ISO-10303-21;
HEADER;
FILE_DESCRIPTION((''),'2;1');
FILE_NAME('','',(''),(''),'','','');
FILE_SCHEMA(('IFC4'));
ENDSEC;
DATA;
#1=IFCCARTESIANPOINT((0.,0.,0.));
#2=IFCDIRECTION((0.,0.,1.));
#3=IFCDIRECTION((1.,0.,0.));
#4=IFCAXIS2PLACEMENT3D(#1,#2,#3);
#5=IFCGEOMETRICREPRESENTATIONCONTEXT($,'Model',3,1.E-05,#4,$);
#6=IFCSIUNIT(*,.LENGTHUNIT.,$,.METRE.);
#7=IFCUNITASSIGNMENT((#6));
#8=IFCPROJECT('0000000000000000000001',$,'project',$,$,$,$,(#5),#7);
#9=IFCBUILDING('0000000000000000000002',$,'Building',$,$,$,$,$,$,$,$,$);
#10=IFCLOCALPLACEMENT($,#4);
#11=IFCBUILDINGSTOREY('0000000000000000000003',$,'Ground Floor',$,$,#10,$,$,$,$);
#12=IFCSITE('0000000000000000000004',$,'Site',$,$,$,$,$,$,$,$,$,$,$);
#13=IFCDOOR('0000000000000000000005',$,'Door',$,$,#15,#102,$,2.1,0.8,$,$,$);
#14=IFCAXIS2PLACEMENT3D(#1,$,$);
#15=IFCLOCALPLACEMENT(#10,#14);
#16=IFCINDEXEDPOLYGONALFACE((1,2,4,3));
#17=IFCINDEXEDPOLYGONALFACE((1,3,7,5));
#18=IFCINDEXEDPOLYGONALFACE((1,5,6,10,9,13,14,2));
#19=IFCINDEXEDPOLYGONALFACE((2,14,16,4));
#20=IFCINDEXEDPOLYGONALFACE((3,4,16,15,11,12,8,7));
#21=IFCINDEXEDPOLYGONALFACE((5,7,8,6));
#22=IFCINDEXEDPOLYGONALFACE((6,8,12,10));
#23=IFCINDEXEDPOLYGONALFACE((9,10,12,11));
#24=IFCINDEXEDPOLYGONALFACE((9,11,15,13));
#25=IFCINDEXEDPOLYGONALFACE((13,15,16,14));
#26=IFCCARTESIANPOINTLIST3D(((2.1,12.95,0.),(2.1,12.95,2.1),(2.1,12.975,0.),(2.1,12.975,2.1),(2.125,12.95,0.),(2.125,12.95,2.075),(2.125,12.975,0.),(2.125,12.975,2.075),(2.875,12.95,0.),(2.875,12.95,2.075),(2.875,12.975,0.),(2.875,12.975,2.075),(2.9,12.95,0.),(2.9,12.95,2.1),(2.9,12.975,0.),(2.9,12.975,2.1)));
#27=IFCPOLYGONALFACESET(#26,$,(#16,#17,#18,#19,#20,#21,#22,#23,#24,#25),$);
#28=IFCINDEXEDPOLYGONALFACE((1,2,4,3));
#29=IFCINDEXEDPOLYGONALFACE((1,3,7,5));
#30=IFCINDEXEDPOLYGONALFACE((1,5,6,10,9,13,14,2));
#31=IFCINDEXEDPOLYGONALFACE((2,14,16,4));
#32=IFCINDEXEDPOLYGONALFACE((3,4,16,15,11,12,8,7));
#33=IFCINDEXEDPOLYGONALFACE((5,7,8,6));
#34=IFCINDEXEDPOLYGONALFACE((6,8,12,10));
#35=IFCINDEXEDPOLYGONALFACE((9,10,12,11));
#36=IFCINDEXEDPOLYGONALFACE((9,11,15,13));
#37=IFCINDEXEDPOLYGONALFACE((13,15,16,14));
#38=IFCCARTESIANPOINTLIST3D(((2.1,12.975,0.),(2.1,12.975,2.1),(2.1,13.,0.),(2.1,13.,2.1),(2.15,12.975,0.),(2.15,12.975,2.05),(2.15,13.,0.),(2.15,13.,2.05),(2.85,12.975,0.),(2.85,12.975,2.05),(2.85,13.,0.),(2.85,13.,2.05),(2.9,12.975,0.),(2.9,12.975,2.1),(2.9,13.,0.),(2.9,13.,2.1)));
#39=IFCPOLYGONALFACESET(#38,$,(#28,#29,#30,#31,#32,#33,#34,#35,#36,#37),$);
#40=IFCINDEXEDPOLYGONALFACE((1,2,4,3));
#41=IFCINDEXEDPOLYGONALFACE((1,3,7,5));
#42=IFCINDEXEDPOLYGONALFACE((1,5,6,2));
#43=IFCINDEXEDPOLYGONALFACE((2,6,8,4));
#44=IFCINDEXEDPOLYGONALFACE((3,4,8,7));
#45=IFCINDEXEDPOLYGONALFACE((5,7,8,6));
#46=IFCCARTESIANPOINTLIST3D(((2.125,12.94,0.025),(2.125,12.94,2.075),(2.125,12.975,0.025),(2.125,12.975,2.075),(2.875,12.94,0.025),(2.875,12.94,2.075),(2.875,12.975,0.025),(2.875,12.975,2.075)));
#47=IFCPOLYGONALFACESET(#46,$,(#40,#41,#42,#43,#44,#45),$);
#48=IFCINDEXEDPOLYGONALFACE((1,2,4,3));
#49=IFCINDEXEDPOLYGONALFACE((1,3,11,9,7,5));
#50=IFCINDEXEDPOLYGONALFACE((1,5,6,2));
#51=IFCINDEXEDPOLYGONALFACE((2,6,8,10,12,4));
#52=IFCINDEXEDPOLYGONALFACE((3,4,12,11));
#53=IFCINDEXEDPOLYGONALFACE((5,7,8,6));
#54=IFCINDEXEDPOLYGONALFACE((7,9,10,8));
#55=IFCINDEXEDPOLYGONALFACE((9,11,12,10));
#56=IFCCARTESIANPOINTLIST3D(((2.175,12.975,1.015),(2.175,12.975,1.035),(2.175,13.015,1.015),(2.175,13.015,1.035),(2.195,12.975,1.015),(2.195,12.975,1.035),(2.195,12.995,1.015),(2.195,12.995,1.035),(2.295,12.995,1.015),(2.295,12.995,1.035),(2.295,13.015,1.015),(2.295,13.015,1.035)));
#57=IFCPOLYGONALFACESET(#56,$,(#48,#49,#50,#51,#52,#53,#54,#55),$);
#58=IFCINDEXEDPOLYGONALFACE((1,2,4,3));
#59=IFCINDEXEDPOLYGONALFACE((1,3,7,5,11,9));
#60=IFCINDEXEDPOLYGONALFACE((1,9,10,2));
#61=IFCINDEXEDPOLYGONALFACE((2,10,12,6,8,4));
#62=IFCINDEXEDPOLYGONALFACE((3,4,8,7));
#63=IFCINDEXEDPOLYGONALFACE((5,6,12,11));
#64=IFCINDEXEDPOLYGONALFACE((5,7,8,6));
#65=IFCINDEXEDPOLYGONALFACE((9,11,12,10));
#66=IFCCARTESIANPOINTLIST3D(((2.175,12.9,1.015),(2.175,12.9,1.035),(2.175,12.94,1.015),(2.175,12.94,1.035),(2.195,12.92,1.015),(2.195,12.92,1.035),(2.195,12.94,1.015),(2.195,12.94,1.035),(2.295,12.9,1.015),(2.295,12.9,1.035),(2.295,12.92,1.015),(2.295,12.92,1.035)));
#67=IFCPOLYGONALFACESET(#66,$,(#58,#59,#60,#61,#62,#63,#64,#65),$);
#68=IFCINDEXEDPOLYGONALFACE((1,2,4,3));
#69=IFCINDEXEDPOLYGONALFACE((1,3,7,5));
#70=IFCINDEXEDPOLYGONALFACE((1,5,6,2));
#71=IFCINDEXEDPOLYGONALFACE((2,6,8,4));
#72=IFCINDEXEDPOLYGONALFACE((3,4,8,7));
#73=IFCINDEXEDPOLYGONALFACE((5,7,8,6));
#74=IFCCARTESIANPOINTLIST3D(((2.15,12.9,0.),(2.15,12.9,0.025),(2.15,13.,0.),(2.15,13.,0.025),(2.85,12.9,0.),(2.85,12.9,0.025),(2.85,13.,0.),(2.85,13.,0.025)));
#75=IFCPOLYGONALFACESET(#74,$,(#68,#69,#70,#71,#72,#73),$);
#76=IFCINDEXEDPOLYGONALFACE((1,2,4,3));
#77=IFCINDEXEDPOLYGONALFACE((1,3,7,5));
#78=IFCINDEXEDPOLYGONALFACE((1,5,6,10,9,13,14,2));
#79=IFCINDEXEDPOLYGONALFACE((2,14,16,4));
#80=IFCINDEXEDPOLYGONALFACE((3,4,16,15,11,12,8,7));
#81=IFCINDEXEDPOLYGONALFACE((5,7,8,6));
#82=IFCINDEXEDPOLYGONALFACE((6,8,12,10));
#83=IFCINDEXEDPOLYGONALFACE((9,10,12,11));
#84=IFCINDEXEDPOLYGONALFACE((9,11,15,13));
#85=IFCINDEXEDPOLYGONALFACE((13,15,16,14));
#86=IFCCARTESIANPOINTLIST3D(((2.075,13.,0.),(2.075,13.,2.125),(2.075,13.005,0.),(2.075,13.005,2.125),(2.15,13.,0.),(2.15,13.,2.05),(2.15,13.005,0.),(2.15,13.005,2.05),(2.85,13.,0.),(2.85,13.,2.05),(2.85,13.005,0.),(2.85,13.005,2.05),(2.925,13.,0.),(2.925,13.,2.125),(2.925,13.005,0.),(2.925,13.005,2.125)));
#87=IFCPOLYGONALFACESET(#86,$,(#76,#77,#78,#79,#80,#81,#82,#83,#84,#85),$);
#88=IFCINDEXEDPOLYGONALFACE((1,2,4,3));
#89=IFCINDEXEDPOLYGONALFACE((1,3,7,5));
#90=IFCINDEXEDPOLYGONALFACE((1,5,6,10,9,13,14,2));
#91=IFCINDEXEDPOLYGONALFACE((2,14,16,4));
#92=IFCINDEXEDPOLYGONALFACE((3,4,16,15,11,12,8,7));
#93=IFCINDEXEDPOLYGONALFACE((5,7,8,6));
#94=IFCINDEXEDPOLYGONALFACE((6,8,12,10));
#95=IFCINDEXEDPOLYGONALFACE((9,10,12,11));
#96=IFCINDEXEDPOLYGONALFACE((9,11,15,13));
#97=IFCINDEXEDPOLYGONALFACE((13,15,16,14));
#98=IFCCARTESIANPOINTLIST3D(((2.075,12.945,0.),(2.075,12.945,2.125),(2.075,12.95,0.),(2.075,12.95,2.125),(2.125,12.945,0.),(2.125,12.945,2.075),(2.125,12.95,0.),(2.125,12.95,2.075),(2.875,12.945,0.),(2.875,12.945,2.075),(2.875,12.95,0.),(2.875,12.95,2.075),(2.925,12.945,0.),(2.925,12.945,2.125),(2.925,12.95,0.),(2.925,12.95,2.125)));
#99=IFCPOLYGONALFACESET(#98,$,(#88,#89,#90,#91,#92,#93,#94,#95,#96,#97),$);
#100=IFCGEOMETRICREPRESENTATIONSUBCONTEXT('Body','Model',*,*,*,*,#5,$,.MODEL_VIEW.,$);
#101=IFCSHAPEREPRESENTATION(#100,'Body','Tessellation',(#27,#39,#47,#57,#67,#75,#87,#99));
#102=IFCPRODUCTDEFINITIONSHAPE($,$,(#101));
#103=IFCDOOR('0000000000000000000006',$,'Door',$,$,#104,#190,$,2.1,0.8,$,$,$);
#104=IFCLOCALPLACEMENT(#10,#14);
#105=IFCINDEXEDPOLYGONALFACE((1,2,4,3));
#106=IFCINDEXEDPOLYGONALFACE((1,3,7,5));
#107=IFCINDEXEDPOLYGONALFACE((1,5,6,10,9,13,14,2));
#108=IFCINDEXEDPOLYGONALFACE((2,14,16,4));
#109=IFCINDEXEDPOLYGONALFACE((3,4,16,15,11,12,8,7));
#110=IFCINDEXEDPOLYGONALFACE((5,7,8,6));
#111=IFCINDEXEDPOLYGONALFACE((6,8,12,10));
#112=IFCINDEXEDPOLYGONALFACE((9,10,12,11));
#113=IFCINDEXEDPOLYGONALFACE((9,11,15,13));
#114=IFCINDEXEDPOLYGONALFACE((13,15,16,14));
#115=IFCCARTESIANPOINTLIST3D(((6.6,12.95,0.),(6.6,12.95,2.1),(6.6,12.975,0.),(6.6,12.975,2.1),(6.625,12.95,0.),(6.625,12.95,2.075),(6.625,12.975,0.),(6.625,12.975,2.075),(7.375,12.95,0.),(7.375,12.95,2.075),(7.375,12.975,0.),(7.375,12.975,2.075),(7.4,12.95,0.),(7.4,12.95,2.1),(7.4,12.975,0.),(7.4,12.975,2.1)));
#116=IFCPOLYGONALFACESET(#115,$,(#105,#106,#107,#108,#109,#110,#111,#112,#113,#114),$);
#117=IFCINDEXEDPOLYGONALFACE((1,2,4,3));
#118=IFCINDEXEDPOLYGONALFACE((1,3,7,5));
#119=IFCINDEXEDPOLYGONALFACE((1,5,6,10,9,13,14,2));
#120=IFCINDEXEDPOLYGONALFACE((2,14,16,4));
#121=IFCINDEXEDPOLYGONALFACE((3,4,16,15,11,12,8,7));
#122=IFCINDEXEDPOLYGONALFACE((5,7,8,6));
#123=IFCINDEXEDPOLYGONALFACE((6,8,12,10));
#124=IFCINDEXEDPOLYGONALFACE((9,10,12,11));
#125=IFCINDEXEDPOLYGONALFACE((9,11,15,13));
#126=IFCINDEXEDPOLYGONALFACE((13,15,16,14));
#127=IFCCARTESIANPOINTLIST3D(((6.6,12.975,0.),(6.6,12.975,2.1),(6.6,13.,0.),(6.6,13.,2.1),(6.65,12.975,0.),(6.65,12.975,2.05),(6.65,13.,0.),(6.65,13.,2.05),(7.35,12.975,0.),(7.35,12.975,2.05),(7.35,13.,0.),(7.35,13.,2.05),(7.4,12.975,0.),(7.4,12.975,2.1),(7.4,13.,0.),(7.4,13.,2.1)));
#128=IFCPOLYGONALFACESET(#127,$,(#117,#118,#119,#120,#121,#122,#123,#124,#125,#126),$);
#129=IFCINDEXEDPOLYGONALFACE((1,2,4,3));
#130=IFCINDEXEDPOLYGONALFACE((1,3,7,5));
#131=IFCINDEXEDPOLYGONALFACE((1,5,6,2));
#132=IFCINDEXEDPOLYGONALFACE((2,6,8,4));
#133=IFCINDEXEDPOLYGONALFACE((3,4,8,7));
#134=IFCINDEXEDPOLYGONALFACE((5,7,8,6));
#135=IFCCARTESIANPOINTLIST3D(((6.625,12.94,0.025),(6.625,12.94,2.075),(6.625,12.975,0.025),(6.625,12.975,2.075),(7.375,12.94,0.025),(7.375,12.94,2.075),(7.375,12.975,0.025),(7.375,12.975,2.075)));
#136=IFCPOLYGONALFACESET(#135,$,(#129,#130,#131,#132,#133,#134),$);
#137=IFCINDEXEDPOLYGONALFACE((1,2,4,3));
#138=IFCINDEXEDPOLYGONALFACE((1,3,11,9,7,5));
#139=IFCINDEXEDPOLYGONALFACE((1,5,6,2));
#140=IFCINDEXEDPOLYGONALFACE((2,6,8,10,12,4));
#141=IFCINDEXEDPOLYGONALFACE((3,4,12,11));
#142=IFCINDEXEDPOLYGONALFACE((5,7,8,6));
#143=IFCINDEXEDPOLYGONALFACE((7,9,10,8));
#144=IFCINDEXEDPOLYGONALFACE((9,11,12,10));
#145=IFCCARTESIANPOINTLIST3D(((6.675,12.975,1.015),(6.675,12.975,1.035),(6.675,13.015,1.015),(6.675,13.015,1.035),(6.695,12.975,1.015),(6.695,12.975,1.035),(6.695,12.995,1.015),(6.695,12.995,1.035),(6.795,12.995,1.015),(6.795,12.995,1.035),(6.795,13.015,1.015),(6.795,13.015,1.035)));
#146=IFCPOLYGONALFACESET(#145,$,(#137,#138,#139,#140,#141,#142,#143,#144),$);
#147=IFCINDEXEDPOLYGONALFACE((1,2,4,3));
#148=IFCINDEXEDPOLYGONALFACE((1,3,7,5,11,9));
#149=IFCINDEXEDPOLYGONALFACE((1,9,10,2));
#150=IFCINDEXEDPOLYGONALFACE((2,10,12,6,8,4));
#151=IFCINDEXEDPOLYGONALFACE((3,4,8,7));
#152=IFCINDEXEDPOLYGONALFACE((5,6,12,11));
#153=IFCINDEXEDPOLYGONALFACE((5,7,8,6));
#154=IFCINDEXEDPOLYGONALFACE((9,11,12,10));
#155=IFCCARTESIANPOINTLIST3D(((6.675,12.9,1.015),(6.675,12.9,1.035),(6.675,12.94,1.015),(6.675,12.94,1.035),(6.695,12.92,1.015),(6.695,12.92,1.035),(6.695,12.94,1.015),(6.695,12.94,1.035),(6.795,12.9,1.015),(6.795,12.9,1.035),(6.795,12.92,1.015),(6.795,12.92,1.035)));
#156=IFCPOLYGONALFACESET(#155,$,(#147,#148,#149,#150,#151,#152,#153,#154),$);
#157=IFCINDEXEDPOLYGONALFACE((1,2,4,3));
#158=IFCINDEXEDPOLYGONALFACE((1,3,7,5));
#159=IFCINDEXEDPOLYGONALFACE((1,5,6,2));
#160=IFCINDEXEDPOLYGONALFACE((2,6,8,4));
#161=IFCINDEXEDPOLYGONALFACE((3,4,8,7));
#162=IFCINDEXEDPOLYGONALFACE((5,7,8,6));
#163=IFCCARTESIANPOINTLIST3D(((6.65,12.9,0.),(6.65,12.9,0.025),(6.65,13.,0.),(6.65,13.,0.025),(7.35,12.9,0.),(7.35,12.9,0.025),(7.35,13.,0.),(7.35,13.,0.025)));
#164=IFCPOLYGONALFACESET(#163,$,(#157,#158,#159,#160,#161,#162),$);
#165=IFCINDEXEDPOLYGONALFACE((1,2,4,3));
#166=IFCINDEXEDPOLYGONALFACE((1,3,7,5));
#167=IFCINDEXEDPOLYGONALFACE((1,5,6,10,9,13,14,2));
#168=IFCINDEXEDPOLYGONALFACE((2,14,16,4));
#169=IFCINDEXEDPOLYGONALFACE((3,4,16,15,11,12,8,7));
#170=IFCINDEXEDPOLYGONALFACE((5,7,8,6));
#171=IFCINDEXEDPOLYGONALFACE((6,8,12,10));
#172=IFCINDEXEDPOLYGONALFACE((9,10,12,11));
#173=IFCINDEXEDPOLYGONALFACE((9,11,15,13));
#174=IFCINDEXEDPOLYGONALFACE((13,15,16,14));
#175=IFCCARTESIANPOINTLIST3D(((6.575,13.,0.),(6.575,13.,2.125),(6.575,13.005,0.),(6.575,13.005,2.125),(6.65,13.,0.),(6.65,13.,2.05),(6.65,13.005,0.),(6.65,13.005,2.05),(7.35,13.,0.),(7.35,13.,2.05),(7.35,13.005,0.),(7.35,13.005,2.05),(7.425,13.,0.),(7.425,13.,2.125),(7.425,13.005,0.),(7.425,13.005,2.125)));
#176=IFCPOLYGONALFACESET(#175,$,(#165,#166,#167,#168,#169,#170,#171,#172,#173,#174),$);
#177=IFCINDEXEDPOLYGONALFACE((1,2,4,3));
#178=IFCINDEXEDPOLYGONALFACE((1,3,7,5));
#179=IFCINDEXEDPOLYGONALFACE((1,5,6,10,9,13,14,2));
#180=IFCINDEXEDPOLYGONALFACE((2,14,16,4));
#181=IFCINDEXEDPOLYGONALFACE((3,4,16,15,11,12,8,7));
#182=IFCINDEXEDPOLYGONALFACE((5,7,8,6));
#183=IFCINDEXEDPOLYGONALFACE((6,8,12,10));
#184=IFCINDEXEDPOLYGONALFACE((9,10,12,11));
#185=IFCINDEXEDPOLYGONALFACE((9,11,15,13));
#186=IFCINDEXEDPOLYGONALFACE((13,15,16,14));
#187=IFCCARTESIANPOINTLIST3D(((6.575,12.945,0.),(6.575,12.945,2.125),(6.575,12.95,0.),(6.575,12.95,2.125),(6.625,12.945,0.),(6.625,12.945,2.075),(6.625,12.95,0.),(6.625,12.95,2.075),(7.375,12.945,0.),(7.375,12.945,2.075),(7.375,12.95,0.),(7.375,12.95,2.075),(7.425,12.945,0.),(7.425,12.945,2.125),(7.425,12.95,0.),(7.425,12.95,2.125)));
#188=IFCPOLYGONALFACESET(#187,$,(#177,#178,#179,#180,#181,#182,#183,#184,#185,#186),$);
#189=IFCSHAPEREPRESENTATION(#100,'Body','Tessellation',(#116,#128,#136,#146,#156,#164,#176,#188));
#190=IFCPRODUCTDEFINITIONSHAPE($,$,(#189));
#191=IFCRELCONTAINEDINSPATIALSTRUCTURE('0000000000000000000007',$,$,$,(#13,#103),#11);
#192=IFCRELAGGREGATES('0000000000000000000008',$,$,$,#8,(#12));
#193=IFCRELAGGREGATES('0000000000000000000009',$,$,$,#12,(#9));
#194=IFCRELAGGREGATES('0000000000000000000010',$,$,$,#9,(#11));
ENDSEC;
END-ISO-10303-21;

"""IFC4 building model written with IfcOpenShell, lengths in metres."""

from ifc_helpers import new_model, si_unit, frame, origin_with_axes, place, context, subcontext, project, spatial, line, indexed_curve, outline, extrude, element, save


model = new_model("IFC4")

# Units and contexts
model_context = context("Model", 3, precision=1e-05, world=origin_with_axes())
body_context = subcontext(model_context, "Body", "Model", "MODEL_VIEW")
ifc_project = project(units=[si_unit("LENGTHUNIT", "METRE")], contexts=[model_context])

# Site, building, storey
site = spatial("IfcSite", under=ifc_project, Name="Site")
building = spatial("IfcBuilding", under=site, Name="Building")
storey_placement = place(None, origin_with_axes())
storey = spatial("IfcBuildingStorey", under=building, at=storey_placement, Name="Ground Floor")

# Doors
door_1_placement = place(storey_placement, frame((2.9, 13.0, 0.0), z_axis=(0.0, 0.0, 1.0), x_axis=(-1.0, 0.0, 0.0)))
element("IfcDoor", 1, at=door_1_placement, inside=storey, Name="Door", OverallHeight=2.1, OverallWidth=0.8, context=body_context, shape_type="SweptSolid", body=[
    extrude(outline(indexed_curve([(0.0, 0.0), (0.0, 2.1), (0.8, 2.1), (0.8, 0.0), (0.775, 0.0), (0.775, 2.075), (0.025, 2.075), (0.025, 0.0)], segments=[line(1, 2, 3, 4, 5, 6, 7, 8, 1)])), frame((0.0, 0.025, 0.0), z_axis=(0.0, -1.0, 0.0), x_axis=(1.0, 0.0, 0.0)), (0.0, 0.0, -1.0), 0.025),
    extrude(outline(indexed_curve([(0.0, 0.0), (0.0, 2.1), (0.8, 2.1), (0.8, 0.0), (0.75, 0.0), (0.75, 2.05), (0.05, 2.05), (0.05, 0.0)], segments=[line(1, 2, 3, 4, 5, 6, 7, 8, 1)])), frame((0.0, 0.0, 0.0), z_axis=(0.0, -1.0, 0.0), x_axis=(1.0, 0.0, 0.0)), (0.0, 0.0, -1.0), 0.025),
    extrude(outline(indexed_curve([(0.0, 0.0), (0.75, 0.0), (0.75, 0.035), (0.0, 0.035)], segments=[line(1, 2, 3, 4, 1)])), frame((0.025, 0.025, 0.025), z_axis=(0.0, 0.0, 1.0), x_axis=(1.0, 0.0, 0.0)), (0.0, 0.0, 1.0), 2.05),
    extrude(outline(indexed_curve([(0.0, 0.0), (0.0, -0.04), (-0.12, -0.04), (-0.12, -0.02), (-0.02, -0.02), (-0.02, 0.0)], segments=[line(1, 2, 3, 4, 5, 6, 1)])), frame((0.725, 0.025, 1.015), z_axis=(0.0, 0.0, 1.0), x_axis=(1.0, 0.0, 0.0)), (0.0, 0.0, 1.0), 0.02),
    extrude(outline(indexed_curve([(0.0, 0.0), (0.0, 0.04), (-0.12, 0.04), (-0.12, 0.02), (-0.02, 0.02), (-0.02, 0.0)], segments=[line(1, 2, 3, 4, 5, 6, 1)])), frame((0.725, 0.06, 1.015), z_axis=(0.0, 0.0, 1.0), x_axis=(1.0, 0.0, 0.0)), (0.0, 0.0, 1.0), 0.02),
    extrude(outline(indexed_curve([(0.0, 0.0), (0.7, 0.0), (0.7, 0.1), (0.0, 0.1)], segments=[line(1, 2, 3, 4, 1)])), frame((0.05, 0.0, 0.0), z_axis=(0.0, 0.0, 1.0), x_axis=(1.0, 0.0, 0.0)), (0.0, 0.0, 1.0), 0.025),
    extrude(outline(indexed_curve([(0.0, 0.0), (0.0, 2.125), (0.85, 2.125), (0.85, 0.0), (0.775, 0.0), (0.775, 2.05), (0.075, 2.05), (0.075, 0.0)], segments=[line(1, 2, 3, 4, 5, 6, 7, 8, 1)])), frame((-0.025, -0.005, 0.0), z_axis=(0.0, -1.0, 0.0), x_axis=(1.0, 0.0, 0.0)), (0.0, 0.0, -1.0), 0.005),
    extrude(outline(indexed_curve([(0.0, 0.0), (0.0, 2.125), (0.85, 2.125), (0.85, 0.0), (0.8, 0.0), (0.8, 2.075), (0.05, 2.075), (0.05, 0.0)], segments=[line(1, 2, 3, 4, 5, 6, 7, 8, 1)])), frame((-0.025, 0.05, 0.0), z_axis=(0.0, -1.0, 0.0), x_axis=(1.0, 0.0, 0.0)), (0.0, 0.0, -1.0), 0.005),
])
door_2_placement = place(storey_placement, frame((7.4, 13.0, 0.0), z_axis=(0.0, 0.0, 1.0), x_axis=(-1.0, 0.0, 0.0)))
element("IfcDoor", 2, at=door_2_placement, inside=storey, Name="Door", OverallHeight=2.1, OverallWidth=0.8, context=body_context, shape_type="SweptSolid", body=[
    extrude(outline(indexed_curve([(0.0, 0.0), (0.0, 2.1), (0.8, 2.1), (0.8, 0.0), (0.775, 0.0), (0.775, 2.075), (0.025, 2.075), (0.025, 0.0)], segments=[line(1, 2, 3, 4, 5, 6, 7, 8, 1)])), frame((0.0, 0.025, 0.0), z_axis=(0.0, -1.0, 0.0), x_axis=(1.0, 0.0, 0.0)), (0.0, 0.0, -1.0), 0.025),
    extrude(outline(indexed_curve([(0.0, 0.0), (0.0, 2.1), (0.8, 2.1), (0.8, 0.0), (0.75, 0.0), (0.75, 2.05), (0.05, 2.05), (0.05, 0.0)], segments=[line(1, 2, 3, 4, 5, 6, 7, 8, 1)])), frame((0.0, 0.0, 0.0), z_axis=(0.0, -1.0, 0.0), x_axis=(1.0, 0.0, 0.0)), (0.0, 0.0, -1.0), 0.025),
    extrude(outline(indexed_curve([(0.0, 0.0), (0.75, 0.0), (0.75, 0.035), (0.0, 0.035)], segments=[line(1, 2, 3, 4, 1)])), frame((0.025, 0.025, 0.025), z_axis=(0.0, 0.0, 1.0), x_axis=(1.0, 0.0, 0.0)), (0.0, 0.0, 1.0), 2.05),
    extrude(outline(indexed_curve([(0.0, 0.0), (0.0, -0.04), (-0.12, -0.04), (-0.12, -0.02), (-0.02, -0.02), (-0.02, 0.0)], segments=[line(1, 2, 3, 4, 5, 6, 1)])), frame((0.725, 0.025, 1.015), z_axis=(0.0, 0.0, 1.0), x_axis=(1.0, 0.0, 0.0)), (0.0, 0.0, 1.0), 0.02),
    extrude(outline(indexed_curve([(0.0, 0.0), (0.0, 0.04), (-0.12, 0.04), (-0.12, 0.02), (-0.02, 0.02), (-0.02, 0.0)], segments=[line(1, 2, 3, 4, 5, 6, 1)])), frame((0.725, 0.06, 1.015), z_axis=(0.0, 0.0, 1.0), x_axis=(1.0, 0.0, 0.0)), (0.0, 0.0, 1.0), 0.02),
    extrude(outline(indexed_curve([(0.0, 0.0), (0.7, 0.0), (0.7, 0.1), (0.0, 0.1)], segments=[line(1, 2, 3, 4, 1)])), frame((0.05, 0.0, 0.0), z_axis=(0.0, 0.0, 1.0), x_axis=(1.0, 0.0, 0.0)), (0.0, 0.0, 1.0), 0.025),
    extrude(outline(indexed_curve([(0.0, 0.0), (0.0, 2.125), (0.85, 2.125), (0.85, 0.0), (0.775, 0.0), (0.775, 2.05), (0.075, 2.05), (0.075, 0.0)], segments=[line(1, 2, 3, 4, 5, 6, 7, 8, 1)])), frame((-0.025, -0.005, 0.0), z_axis=(0.0, -1.0, 0.0), x_axis=(1.0, 0.0, 0.0)), (0.0, 0.0, -1.0), 0.005),
    extrude(outline(indexed_curve([(0.0, 0.0), (0.0, 2.125), (0.85, 2.125), (0.85, 0.0), (0.8, 0.0), (0.8, 2.075), (0.05, 2.075), (0.05, 0.0)], segments=[line(1, 2, 3, 4, 5, 6, 7, 8, 1)])), frame((-0.025, 0.05, 0.0), z_axis=(0.0, -1.0, 0.0), x_axis=(1.0, 0.0, 0.0)), (0.0, 0.0, -1.0), 0.005),
])

save(model, "model.ifc")
